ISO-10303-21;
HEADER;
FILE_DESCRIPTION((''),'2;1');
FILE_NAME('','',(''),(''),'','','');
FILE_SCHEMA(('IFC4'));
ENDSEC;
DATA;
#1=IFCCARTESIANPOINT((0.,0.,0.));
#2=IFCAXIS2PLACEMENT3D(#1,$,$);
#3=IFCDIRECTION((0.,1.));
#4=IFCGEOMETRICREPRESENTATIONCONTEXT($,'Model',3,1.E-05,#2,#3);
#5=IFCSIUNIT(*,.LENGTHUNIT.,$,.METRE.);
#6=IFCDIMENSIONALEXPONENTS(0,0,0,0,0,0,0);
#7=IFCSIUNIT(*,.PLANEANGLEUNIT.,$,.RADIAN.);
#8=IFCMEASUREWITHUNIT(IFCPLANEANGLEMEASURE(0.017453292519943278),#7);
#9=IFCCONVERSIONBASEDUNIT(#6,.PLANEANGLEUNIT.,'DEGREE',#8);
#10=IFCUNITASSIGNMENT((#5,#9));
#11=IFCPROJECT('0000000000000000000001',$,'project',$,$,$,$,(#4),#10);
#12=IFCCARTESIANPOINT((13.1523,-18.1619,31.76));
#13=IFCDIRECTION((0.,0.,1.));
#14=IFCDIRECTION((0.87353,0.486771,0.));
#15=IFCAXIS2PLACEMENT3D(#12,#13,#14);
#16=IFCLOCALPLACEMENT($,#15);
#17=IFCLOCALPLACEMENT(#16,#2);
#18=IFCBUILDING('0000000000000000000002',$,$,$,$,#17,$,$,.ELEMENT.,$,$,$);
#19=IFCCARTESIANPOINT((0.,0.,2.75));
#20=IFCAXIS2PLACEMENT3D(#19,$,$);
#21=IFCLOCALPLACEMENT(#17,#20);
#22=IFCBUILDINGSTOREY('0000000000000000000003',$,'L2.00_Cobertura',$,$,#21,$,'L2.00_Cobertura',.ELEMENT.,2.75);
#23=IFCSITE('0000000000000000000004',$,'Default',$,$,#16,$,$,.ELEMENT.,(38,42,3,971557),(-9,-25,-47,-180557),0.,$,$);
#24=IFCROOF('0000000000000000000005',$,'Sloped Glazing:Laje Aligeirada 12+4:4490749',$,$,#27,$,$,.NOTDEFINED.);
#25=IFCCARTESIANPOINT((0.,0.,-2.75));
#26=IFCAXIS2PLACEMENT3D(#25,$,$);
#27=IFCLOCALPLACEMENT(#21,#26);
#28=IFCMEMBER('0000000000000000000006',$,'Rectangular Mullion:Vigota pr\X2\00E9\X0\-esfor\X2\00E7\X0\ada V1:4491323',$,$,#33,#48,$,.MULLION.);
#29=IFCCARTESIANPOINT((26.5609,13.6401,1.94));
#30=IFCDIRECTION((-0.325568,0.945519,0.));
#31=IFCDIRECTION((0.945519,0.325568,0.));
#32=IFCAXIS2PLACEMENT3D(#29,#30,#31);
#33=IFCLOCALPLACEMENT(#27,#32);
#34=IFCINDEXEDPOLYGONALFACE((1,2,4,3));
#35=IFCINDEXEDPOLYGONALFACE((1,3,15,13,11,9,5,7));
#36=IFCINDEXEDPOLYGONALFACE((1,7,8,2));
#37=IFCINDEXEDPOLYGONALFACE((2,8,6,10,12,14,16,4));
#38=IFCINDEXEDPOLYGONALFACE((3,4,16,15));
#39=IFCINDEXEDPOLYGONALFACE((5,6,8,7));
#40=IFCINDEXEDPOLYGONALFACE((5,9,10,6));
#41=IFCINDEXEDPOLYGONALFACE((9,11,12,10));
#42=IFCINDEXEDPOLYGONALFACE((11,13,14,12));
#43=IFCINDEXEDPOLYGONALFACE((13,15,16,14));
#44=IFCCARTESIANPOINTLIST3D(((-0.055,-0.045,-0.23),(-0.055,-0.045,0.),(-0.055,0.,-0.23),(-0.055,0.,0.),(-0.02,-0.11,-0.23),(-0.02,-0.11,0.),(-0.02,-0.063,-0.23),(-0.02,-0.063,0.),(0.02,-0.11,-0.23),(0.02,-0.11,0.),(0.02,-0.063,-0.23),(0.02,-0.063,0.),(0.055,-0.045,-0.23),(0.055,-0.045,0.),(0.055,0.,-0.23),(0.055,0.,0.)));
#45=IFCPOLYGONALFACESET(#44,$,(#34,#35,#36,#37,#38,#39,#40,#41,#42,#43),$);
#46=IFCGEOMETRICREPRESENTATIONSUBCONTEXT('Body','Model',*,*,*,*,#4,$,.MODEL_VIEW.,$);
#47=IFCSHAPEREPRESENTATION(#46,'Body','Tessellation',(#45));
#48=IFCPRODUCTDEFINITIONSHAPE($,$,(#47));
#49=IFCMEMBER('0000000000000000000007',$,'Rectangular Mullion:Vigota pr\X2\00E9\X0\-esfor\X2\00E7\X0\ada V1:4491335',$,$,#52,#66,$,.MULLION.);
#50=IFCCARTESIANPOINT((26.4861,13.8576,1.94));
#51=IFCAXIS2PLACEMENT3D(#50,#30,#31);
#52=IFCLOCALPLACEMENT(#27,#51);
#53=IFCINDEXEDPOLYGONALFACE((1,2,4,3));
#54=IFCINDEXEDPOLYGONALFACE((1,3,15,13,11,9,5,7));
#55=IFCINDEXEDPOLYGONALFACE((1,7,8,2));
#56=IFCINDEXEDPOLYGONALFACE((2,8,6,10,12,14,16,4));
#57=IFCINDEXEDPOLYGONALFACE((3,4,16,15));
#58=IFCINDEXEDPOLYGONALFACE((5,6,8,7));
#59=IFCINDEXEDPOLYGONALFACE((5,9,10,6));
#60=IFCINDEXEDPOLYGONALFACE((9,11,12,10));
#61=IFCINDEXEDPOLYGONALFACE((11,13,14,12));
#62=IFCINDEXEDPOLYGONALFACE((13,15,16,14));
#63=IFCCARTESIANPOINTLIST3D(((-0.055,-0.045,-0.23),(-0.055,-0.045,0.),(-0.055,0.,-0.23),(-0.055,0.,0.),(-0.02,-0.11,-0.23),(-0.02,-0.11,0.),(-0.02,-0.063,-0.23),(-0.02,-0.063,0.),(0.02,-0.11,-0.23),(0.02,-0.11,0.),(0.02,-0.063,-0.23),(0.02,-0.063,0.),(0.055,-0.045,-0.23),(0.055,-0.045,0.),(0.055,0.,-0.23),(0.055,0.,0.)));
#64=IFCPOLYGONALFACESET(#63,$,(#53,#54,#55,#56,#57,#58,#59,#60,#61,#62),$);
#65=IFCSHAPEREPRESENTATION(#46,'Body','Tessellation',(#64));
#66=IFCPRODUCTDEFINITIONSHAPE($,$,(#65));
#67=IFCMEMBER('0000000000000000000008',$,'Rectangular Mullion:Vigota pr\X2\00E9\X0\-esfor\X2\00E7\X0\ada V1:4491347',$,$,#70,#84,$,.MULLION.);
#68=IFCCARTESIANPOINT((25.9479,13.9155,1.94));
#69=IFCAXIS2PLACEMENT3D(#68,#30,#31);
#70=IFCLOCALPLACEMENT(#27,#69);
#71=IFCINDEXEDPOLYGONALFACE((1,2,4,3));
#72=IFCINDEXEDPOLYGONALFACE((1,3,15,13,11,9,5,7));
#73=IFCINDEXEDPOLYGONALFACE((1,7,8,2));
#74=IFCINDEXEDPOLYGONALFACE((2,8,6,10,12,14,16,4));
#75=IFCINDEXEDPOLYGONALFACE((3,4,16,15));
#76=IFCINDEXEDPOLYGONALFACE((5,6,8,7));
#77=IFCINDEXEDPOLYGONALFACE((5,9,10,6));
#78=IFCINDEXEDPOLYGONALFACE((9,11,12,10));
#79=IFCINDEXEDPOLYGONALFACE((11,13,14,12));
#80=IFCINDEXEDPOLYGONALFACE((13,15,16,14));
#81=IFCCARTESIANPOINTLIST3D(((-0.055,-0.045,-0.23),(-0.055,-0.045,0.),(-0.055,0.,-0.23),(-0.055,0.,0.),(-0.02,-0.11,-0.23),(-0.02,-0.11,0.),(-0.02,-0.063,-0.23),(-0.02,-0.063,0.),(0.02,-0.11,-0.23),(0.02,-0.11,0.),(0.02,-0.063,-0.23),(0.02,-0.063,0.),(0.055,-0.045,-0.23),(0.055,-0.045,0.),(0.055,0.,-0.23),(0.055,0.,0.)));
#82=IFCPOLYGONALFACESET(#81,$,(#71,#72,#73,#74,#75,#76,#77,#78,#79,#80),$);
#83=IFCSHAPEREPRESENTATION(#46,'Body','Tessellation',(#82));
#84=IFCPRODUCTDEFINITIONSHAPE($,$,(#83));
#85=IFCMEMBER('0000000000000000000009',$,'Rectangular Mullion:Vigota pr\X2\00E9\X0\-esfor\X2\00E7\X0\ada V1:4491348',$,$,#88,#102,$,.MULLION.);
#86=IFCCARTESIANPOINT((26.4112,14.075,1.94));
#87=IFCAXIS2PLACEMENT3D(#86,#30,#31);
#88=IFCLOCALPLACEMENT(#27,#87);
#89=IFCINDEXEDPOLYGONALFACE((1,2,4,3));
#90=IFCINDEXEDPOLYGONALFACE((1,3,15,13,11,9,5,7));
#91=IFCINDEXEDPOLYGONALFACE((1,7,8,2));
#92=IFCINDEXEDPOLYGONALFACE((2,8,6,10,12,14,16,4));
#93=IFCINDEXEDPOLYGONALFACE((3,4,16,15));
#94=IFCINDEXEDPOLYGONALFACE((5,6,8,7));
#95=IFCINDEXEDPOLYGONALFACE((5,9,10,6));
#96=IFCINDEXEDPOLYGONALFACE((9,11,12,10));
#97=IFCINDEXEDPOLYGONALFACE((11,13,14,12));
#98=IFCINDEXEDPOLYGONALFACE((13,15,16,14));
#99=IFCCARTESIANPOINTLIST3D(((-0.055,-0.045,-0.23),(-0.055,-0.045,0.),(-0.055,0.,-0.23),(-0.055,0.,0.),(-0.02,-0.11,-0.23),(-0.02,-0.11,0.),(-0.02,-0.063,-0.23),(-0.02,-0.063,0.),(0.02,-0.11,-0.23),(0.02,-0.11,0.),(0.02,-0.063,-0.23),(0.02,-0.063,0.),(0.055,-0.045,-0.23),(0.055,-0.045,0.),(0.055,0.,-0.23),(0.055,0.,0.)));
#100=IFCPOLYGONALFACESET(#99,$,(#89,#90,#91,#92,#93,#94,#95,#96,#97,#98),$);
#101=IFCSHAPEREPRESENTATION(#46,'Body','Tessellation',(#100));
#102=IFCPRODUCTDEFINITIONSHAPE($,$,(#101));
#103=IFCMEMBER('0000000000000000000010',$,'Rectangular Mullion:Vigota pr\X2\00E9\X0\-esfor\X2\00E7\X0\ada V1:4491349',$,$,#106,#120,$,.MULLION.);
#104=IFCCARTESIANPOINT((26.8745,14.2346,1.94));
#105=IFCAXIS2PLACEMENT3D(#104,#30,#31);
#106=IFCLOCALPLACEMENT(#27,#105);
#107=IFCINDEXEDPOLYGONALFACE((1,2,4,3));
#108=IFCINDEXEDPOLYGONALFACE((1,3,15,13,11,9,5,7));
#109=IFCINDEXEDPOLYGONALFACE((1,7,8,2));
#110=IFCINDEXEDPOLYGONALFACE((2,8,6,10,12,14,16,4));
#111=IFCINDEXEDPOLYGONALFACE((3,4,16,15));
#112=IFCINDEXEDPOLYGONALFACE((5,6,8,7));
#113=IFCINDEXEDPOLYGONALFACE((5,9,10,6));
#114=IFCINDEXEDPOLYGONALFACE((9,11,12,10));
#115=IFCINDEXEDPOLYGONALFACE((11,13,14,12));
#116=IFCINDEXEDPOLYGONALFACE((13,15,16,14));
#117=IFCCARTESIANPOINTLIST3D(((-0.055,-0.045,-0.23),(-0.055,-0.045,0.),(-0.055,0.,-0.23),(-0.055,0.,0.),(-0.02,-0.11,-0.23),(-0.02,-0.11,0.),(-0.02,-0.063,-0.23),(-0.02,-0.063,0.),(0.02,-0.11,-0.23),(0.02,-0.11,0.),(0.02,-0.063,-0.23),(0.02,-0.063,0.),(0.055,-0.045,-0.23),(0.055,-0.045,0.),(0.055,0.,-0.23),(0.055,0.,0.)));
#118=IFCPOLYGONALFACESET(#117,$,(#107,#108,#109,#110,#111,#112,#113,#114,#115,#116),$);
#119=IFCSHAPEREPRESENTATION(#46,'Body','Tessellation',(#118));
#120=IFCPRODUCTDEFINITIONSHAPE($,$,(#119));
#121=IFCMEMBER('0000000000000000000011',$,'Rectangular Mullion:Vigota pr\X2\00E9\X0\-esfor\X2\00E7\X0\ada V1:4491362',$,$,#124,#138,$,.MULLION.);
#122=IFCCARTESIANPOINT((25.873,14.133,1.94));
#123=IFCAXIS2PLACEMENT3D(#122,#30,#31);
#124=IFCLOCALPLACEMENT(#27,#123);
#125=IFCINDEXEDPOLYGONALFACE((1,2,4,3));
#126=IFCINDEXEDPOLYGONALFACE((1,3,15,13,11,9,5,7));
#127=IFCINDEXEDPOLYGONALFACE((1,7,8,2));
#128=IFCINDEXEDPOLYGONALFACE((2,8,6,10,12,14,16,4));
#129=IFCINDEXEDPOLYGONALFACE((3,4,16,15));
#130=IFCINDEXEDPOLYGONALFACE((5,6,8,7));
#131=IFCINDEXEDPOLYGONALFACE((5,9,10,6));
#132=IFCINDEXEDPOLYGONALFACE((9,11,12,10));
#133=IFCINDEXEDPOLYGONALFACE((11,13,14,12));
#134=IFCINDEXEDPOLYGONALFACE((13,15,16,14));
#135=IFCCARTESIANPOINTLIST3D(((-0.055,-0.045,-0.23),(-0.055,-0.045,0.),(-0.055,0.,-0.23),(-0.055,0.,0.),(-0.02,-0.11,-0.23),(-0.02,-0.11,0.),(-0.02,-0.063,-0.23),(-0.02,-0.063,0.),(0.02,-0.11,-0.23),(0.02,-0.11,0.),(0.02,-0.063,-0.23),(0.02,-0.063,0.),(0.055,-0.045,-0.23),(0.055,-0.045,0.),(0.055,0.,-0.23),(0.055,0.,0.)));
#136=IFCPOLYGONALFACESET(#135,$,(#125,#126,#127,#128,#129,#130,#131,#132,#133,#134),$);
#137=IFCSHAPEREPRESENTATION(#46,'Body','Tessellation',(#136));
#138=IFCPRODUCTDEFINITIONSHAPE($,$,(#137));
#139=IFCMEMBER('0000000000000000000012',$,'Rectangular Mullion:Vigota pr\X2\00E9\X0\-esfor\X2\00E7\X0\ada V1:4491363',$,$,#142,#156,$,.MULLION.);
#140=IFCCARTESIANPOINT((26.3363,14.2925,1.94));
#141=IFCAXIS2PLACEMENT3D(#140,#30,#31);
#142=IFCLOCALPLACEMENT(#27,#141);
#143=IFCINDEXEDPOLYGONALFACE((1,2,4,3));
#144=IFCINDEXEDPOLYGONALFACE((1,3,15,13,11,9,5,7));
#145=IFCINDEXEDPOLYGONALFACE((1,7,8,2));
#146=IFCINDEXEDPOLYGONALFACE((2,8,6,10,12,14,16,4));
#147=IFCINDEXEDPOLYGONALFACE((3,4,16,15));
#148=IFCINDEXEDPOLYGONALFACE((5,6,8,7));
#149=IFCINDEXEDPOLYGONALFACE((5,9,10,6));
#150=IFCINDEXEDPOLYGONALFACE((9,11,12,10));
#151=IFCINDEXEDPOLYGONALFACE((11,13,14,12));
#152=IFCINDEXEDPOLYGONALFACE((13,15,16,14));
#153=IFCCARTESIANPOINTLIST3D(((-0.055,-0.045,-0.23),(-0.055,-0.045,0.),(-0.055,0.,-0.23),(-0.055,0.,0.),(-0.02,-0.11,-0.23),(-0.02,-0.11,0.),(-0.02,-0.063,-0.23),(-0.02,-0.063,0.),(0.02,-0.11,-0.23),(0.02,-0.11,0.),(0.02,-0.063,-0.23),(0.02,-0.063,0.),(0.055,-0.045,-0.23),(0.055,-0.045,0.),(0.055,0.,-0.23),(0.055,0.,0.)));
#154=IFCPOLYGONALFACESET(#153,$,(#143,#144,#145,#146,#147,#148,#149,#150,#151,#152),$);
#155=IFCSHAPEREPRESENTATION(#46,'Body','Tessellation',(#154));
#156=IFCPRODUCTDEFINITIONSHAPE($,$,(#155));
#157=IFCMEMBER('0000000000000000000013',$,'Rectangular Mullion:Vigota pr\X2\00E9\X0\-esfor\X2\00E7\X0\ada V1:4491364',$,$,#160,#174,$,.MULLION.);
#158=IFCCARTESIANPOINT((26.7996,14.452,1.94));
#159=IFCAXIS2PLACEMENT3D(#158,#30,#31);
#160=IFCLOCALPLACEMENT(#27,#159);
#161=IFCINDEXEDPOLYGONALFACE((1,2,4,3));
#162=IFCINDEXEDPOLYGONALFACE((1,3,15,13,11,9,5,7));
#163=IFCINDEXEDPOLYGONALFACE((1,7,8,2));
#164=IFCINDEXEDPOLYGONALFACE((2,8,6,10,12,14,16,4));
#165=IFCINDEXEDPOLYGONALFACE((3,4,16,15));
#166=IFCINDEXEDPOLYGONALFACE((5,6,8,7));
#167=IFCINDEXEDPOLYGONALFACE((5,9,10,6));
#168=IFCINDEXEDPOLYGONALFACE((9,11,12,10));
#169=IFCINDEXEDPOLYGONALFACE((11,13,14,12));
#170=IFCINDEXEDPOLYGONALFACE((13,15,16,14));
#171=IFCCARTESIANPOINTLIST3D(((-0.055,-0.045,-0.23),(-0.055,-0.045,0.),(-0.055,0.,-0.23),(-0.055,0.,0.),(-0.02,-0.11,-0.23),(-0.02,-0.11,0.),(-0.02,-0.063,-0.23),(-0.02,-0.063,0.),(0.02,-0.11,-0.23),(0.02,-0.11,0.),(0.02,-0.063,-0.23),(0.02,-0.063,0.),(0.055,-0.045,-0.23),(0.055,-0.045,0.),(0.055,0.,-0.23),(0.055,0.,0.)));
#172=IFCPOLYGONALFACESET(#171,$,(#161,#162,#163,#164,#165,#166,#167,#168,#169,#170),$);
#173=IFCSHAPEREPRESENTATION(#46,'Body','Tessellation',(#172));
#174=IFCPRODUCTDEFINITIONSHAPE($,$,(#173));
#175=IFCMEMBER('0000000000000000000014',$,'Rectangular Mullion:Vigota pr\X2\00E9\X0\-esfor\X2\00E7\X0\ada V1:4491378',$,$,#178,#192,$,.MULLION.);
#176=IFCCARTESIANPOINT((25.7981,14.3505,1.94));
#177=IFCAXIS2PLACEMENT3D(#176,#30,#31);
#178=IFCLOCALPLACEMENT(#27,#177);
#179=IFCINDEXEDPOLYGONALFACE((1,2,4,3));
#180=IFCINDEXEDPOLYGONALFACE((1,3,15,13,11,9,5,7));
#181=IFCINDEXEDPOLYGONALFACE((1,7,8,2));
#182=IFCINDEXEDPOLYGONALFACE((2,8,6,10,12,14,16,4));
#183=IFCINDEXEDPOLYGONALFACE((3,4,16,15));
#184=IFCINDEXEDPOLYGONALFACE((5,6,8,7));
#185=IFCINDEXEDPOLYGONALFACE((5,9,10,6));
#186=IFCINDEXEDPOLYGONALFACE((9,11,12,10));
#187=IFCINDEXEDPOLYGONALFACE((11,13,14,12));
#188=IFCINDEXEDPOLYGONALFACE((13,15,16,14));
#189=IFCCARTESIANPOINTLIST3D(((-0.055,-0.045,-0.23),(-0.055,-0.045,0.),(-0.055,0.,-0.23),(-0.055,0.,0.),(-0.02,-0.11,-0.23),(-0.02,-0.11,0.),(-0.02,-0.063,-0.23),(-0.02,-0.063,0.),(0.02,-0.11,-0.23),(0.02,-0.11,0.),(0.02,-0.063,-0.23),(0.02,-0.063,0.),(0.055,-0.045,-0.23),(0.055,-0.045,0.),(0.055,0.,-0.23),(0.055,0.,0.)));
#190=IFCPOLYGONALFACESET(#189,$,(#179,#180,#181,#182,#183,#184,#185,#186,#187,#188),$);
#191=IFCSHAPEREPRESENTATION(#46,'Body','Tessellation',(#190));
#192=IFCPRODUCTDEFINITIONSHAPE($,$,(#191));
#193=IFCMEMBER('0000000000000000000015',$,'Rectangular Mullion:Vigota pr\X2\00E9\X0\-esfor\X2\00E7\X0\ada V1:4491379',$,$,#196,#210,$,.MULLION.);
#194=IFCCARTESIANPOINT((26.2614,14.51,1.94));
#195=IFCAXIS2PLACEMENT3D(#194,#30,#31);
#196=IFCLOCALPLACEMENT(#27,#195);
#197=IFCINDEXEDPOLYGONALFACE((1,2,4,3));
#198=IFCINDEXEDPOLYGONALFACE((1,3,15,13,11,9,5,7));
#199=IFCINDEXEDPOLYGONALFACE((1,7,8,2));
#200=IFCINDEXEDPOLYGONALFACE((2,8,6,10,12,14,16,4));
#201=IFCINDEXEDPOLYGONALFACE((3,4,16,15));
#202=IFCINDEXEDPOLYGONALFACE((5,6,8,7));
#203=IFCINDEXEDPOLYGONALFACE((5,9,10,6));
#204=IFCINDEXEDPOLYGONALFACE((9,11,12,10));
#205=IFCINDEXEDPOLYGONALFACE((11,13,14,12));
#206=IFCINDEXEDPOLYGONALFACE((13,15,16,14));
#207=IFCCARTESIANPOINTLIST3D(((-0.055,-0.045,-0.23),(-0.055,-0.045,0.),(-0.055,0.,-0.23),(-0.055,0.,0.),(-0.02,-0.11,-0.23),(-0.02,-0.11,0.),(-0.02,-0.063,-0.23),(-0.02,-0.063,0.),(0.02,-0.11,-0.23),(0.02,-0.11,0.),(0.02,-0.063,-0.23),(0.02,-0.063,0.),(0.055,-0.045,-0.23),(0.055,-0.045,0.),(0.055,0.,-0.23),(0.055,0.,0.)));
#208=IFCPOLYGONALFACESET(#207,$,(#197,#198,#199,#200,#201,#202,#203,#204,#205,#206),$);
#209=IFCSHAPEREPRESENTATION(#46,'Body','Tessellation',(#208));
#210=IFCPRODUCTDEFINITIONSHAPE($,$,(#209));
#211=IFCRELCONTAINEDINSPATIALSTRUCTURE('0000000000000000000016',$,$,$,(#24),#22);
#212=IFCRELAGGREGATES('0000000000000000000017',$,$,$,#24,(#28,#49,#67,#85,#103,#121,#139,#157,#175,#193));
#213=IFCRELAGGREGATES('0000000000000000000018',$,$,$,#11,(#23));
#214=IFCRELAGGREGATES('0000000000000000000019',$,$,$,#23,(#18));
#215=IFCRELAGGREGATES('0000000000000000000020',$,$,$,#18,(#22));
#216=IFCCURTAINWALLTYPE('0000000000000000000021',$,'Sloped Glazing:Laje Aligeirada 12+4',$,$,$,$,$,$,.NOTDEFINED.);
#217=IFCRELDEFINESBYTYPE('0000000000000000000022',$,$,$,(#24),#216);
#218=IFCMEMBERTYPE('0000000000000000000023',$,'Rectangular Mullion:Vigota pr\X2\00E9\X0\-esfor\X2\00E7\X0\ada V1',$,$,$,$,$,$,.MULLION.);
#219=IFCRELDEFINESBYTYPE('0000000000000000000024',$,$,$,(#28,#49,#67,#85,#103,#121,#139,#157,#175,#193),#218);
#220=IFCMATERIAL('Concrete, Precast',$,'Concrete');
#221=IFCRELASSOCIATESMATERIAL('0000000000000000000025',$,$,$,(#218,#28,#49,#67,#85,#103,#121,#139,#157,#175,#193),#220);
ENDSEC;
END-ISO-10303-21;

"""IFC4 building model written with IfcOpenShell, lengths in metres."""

from ifc_helpers import new_model, entity, si_unit, converted_unit, direction, frame, origin, place, context, subcontext, project, spatial, indexed_curve, outline, extrude, source, transform, mapped, material, type_object, type_shapes, element, aggregate, save


model = new_model("IFC4")

# Units and contexts
model_context = context("Model", 3, precision=1e-05, world=origin(), true_north=direction((0.0, 1.0)))
body_context = subcontext(model_context, "Body", "Model", "MODEL_VIEW")
ifc_project = project(units=[si_unit("LENGTHUNIT", "METRE"), converted_unit("PLANEANGLEUNIT", "DEGREE", entity("IfcPlaneAngleMeasure", 0.017453292519943278), si_unit("PLANEANGLEUNIT", "RADIAN"), dimensions=[0, 0, 0, 0, 0, 0, 0])], contexts=[model_context])

# Site, building, storey
site_placement = place(None, frame((13.1523, -18.1619, 31.76), z_axis=(0.0, 0.0, 1.0), x_axis=(0.87353, 0.486771, 0.0)))
site = spatial("IfcSite", under=ifc_project, at=site_placement, Name="Default", CompositionType="ELEMENT", RefLatitude=(38, 42, 3, 971557), RefLongitude=(-9, -25, -47, -180557), RefElevation=0.0)
building_placement = place(site_placement, origin())
building = spatial("IfcBuilding", under=site, at=building_placement, CompositionType="ELEMENT")
storey_placement = place(building_placement, frame((0.0, 0.0, 2.75)))
storey = spatial("IfcBuildingStorey", under=building, at=storey_placement, Name="L2.00_Cobertura", LongName="L2.00_Cobertura", CompositionType="ELEMENT", Elevation=2.75)

# Roof, members
curtain_wall_type = type_object("IfcCurtainWallType", Name="Sloped Glazing:Laje Aligeirada 12+4", PredefinedType="NOTDEFINED")
roof_placement = place(storey_placement, frame((0.0, 0.0, -2.75)))
roof = element("IfcRoof", 1, at=roof_placement, inside=storey, type_object=curtain_wall_type, Name="Sloped Glazing:Laje Aligeirada 12+4:4490749", PredefinedType="NOTDEFINED")
ifc_material_1 = material(Name="Concrete, Precast", Category="Concrete")
member_type_1 = type_object("IfcMemberType", Name="Rectangular Mullion:Vigota pré-esforçada V1", PredefinedType="MULLION", material=ifc_material_1)
shared_shape_1 = source(origin(), body_context, "Body", "SweptSolid", [
    extrude(outline(indexed_curve([(-0.055, -0.0545), (0.055, -0.0545), (0.055, -0.0095), (0.02, 0.0085), (0.02, 0.0555), (-0.02, 0.0555), (-0.02, 0.0085), (-0.055, -0.0095), (-0.055, -0.0545)], self_intersect=False)), frame((0.0, -0.0545, -0.23), z_axis=(0.0, 0.0, 1.0), x_axis=(-1.0, 0.0, 0.0)), (0.0, 0.0, 1.0), 0.23),
])
type_shapes(member_type_1, [shared_shape_1])
member_1_placement = place(roof_placement, frame((26.5609, 13.6401, 1.94), z_axis=(-0.325568, 0.945519, 0.0), x_axis=(0.945519, 0.325568, 0.0)))
member_1 = element("IfcMember", 2, at=member_1_placement, type_object=member_type_1, material=ifc_material_1, Name="Rectangular Mullion:Vigota pré-esforçada V1:4491323", PredefinedType="MULLION", context=body_context, shape_type="MappedRepresentation", body=[
    mapped(shared_shape_1, transform((0.0, 0.0, 0.0), scale=1.0)),
])
member_2_placement = place(roof_placement, frame((26.4861, 13.8576, 1.94), z_axis=(-0.325568, 0.945519, 0.0), x_axis=(0.945519, 0.325568, 0.0)))
member_2 = element("IfcMember", 3, at=member_2_placement, type_object=member_type_1, material=ifc_material_1, Name="Rectangular Mullion:Vigota pré-esforçada V1:4491335", PredefinedType="MULLION", context=body_context, shape_type="MappedRepresentation", body=[
    mapped(shared_shape_1, transform((0.0, 0.0, 0.0), scale=1.0)),
])
member_3_placement = place(roof_placement, frame((25.9479, 13.9155, 1.94), z_axis=(-0.325568, 0.945519, 0.0), x_axis=(0.945519, 0.325568, 0.0)))
member_3 = element("IfcMember", 4, at=member_3_placement, type_object=member_type_1, material=ifc_material_1, Name="Rectangular Mullion:Vigota pré-esforçada V1:4491347", PredefinedType="MULLION", context=body_context, shape_type="MappedRepresentation", body=[
    mapped(shared_shape_1, transform((0.0, 0.0, 0.0), scale=1.0)),
])
member_4_placement = place(roof_placement, frame((26.4112, 14.075, 1.94), z_axis=(-0.325568, 0.945519, 0.0), x_axis=(0.945519, 0.325568, 0.0)))
member_4 = element("IfcMember", 5, at=member_4_placement, type_object=member_type_1, material=ifc_material_1, Name="Rectangular Mullion:Vigota pré-esforçada V1:4491348", PredefinedType="MULLION", context=body_context, shape_type="MappedRepresentation", body=[
    mapped(shared_shape_1, transform((0.0, 0.0, 0.0), scale=1.0)),
])
member_5_placement = place(roof_placement, frame((26.8745, 14.2346, 1.94), z_axis=(-0.325568, 0.945519, 0.0), x_axis=(0.945519, 0.325568, 0.0)))
member_5 = element("IfcMember", 6, at=member_5_placement, type_object=member_type_1, material=ifc_material_1, Name="Rectangular Mullion:Vigota pré-esforçada V1:4491349", PredefinedType="MULLION", context=body_context, shape_type="MappedRepresentation", body=[
    mapped(shared_shape_1, transform((0.0, 0.0, 0.0), scale=1.0)),
])
member_6_placement = place(roof_placement, frame((25.873, 14.133, 1.94), z_axis=(-0.325568, 0.945519, 0.0), x_axis=(0.945519, 0.325568, 0.0)))
member_6 = element("IfcMember", 7, at=member_6_placement, type_object=member_type_1, material=ifc_material_1, Name="Rectangular Mullion:Vigota pré-esforçada V1:4491362", PredefinedType="MULLION", context=body_context, shape_type="MappedRepresentation", body=[
    mapped(shared_shape_1, transform((0.0, 0.0, 0.0), scale=1.0)),
])
member_7_placement = place(roof_placement, frame((26.3363, 14.2925, 1.94), z_axis=(-0.325568, 0.945519, 0.0), x_axis=(0.945519, 0.325568, 0.0)))
member_7 = element("IfcMember", 8, at=member_7_placement, type_object=member_type_1, material=ifc_material_1, Name="Rectangular Mullion:Vigota pré-esforçada V1:4491363", PredefinedType="MULLION", context=body_context, shape_type="MappedRepresentation", body=[
    mapped(shared_shape_1, transform((0.0, 0.0, 0.0), scale=1.0)),
])
member_8_placement = place(roof_placement, frame((26.7996, 14.452, 1.94), z_axis=(-0.325568, 0.945519, 0.0), x_axis=(0.945519, 0.325568, 0.0)))
member_8 = element("IfcMember", 9, at=member_8_placement, type_object=member_type_1, material=ifc_material_1, Name="Rectangular Mullion:Vigota pré-esforçada V1:4491364", PredefinedType="MULLION", context=body_context, shape_type="MappedRepresentation", body=[
    mapped(shared_shape_1, transform((0.0, 0.0, 0.0), scale=1.0)),
])
member_9_placement = place(roof_placement, frame((25.7981, 14.3505, 1.94), z_axis=(-0.325568, 0.945519, 0.0), x_axis=(0.945519, 0.325568, 0.0)))
member_9 = element("IfcMember", 10, at=member_9_placement, type_object=member_type_1, material=ifc_material_1, Name="Rectangular Mullion:Vigota pré-esforçada V1:4491378", PredefinedType="MULLION", context=body_context, shape_type="MappedRepresentation", body=[
    mapped(shared_shape_1, transform((0.0, 0.0, 0.0), scale=1.0)),
])
member_10_placement = place(roof_placement, frame((26.2614, 14.51, 1.94), z_axis=(-0.325568, 0.945519, 0.0), x_axis=(0.945519, 0.325568, 0.0)))
member_10 = element("IfcMember", 11, at=member_10_placement, type_object=member_type_1, material=ifc_material_1, Name="Rectangular Mullion:Vigota pré-esforçada V1:4491379", PredefinedType="MULLION", context=body_context, shape_type="MappedRepresentation", body=[
    mapped(shared_shape_1, transform((0.0, 0.0, 0.0), scale=1.0)),
])
aggregate(roof, [member_1, member_2, member_3, member_4, member_5, member_6, member_7, member_8, member_9, member_10])

save(model, "model.ifc")
